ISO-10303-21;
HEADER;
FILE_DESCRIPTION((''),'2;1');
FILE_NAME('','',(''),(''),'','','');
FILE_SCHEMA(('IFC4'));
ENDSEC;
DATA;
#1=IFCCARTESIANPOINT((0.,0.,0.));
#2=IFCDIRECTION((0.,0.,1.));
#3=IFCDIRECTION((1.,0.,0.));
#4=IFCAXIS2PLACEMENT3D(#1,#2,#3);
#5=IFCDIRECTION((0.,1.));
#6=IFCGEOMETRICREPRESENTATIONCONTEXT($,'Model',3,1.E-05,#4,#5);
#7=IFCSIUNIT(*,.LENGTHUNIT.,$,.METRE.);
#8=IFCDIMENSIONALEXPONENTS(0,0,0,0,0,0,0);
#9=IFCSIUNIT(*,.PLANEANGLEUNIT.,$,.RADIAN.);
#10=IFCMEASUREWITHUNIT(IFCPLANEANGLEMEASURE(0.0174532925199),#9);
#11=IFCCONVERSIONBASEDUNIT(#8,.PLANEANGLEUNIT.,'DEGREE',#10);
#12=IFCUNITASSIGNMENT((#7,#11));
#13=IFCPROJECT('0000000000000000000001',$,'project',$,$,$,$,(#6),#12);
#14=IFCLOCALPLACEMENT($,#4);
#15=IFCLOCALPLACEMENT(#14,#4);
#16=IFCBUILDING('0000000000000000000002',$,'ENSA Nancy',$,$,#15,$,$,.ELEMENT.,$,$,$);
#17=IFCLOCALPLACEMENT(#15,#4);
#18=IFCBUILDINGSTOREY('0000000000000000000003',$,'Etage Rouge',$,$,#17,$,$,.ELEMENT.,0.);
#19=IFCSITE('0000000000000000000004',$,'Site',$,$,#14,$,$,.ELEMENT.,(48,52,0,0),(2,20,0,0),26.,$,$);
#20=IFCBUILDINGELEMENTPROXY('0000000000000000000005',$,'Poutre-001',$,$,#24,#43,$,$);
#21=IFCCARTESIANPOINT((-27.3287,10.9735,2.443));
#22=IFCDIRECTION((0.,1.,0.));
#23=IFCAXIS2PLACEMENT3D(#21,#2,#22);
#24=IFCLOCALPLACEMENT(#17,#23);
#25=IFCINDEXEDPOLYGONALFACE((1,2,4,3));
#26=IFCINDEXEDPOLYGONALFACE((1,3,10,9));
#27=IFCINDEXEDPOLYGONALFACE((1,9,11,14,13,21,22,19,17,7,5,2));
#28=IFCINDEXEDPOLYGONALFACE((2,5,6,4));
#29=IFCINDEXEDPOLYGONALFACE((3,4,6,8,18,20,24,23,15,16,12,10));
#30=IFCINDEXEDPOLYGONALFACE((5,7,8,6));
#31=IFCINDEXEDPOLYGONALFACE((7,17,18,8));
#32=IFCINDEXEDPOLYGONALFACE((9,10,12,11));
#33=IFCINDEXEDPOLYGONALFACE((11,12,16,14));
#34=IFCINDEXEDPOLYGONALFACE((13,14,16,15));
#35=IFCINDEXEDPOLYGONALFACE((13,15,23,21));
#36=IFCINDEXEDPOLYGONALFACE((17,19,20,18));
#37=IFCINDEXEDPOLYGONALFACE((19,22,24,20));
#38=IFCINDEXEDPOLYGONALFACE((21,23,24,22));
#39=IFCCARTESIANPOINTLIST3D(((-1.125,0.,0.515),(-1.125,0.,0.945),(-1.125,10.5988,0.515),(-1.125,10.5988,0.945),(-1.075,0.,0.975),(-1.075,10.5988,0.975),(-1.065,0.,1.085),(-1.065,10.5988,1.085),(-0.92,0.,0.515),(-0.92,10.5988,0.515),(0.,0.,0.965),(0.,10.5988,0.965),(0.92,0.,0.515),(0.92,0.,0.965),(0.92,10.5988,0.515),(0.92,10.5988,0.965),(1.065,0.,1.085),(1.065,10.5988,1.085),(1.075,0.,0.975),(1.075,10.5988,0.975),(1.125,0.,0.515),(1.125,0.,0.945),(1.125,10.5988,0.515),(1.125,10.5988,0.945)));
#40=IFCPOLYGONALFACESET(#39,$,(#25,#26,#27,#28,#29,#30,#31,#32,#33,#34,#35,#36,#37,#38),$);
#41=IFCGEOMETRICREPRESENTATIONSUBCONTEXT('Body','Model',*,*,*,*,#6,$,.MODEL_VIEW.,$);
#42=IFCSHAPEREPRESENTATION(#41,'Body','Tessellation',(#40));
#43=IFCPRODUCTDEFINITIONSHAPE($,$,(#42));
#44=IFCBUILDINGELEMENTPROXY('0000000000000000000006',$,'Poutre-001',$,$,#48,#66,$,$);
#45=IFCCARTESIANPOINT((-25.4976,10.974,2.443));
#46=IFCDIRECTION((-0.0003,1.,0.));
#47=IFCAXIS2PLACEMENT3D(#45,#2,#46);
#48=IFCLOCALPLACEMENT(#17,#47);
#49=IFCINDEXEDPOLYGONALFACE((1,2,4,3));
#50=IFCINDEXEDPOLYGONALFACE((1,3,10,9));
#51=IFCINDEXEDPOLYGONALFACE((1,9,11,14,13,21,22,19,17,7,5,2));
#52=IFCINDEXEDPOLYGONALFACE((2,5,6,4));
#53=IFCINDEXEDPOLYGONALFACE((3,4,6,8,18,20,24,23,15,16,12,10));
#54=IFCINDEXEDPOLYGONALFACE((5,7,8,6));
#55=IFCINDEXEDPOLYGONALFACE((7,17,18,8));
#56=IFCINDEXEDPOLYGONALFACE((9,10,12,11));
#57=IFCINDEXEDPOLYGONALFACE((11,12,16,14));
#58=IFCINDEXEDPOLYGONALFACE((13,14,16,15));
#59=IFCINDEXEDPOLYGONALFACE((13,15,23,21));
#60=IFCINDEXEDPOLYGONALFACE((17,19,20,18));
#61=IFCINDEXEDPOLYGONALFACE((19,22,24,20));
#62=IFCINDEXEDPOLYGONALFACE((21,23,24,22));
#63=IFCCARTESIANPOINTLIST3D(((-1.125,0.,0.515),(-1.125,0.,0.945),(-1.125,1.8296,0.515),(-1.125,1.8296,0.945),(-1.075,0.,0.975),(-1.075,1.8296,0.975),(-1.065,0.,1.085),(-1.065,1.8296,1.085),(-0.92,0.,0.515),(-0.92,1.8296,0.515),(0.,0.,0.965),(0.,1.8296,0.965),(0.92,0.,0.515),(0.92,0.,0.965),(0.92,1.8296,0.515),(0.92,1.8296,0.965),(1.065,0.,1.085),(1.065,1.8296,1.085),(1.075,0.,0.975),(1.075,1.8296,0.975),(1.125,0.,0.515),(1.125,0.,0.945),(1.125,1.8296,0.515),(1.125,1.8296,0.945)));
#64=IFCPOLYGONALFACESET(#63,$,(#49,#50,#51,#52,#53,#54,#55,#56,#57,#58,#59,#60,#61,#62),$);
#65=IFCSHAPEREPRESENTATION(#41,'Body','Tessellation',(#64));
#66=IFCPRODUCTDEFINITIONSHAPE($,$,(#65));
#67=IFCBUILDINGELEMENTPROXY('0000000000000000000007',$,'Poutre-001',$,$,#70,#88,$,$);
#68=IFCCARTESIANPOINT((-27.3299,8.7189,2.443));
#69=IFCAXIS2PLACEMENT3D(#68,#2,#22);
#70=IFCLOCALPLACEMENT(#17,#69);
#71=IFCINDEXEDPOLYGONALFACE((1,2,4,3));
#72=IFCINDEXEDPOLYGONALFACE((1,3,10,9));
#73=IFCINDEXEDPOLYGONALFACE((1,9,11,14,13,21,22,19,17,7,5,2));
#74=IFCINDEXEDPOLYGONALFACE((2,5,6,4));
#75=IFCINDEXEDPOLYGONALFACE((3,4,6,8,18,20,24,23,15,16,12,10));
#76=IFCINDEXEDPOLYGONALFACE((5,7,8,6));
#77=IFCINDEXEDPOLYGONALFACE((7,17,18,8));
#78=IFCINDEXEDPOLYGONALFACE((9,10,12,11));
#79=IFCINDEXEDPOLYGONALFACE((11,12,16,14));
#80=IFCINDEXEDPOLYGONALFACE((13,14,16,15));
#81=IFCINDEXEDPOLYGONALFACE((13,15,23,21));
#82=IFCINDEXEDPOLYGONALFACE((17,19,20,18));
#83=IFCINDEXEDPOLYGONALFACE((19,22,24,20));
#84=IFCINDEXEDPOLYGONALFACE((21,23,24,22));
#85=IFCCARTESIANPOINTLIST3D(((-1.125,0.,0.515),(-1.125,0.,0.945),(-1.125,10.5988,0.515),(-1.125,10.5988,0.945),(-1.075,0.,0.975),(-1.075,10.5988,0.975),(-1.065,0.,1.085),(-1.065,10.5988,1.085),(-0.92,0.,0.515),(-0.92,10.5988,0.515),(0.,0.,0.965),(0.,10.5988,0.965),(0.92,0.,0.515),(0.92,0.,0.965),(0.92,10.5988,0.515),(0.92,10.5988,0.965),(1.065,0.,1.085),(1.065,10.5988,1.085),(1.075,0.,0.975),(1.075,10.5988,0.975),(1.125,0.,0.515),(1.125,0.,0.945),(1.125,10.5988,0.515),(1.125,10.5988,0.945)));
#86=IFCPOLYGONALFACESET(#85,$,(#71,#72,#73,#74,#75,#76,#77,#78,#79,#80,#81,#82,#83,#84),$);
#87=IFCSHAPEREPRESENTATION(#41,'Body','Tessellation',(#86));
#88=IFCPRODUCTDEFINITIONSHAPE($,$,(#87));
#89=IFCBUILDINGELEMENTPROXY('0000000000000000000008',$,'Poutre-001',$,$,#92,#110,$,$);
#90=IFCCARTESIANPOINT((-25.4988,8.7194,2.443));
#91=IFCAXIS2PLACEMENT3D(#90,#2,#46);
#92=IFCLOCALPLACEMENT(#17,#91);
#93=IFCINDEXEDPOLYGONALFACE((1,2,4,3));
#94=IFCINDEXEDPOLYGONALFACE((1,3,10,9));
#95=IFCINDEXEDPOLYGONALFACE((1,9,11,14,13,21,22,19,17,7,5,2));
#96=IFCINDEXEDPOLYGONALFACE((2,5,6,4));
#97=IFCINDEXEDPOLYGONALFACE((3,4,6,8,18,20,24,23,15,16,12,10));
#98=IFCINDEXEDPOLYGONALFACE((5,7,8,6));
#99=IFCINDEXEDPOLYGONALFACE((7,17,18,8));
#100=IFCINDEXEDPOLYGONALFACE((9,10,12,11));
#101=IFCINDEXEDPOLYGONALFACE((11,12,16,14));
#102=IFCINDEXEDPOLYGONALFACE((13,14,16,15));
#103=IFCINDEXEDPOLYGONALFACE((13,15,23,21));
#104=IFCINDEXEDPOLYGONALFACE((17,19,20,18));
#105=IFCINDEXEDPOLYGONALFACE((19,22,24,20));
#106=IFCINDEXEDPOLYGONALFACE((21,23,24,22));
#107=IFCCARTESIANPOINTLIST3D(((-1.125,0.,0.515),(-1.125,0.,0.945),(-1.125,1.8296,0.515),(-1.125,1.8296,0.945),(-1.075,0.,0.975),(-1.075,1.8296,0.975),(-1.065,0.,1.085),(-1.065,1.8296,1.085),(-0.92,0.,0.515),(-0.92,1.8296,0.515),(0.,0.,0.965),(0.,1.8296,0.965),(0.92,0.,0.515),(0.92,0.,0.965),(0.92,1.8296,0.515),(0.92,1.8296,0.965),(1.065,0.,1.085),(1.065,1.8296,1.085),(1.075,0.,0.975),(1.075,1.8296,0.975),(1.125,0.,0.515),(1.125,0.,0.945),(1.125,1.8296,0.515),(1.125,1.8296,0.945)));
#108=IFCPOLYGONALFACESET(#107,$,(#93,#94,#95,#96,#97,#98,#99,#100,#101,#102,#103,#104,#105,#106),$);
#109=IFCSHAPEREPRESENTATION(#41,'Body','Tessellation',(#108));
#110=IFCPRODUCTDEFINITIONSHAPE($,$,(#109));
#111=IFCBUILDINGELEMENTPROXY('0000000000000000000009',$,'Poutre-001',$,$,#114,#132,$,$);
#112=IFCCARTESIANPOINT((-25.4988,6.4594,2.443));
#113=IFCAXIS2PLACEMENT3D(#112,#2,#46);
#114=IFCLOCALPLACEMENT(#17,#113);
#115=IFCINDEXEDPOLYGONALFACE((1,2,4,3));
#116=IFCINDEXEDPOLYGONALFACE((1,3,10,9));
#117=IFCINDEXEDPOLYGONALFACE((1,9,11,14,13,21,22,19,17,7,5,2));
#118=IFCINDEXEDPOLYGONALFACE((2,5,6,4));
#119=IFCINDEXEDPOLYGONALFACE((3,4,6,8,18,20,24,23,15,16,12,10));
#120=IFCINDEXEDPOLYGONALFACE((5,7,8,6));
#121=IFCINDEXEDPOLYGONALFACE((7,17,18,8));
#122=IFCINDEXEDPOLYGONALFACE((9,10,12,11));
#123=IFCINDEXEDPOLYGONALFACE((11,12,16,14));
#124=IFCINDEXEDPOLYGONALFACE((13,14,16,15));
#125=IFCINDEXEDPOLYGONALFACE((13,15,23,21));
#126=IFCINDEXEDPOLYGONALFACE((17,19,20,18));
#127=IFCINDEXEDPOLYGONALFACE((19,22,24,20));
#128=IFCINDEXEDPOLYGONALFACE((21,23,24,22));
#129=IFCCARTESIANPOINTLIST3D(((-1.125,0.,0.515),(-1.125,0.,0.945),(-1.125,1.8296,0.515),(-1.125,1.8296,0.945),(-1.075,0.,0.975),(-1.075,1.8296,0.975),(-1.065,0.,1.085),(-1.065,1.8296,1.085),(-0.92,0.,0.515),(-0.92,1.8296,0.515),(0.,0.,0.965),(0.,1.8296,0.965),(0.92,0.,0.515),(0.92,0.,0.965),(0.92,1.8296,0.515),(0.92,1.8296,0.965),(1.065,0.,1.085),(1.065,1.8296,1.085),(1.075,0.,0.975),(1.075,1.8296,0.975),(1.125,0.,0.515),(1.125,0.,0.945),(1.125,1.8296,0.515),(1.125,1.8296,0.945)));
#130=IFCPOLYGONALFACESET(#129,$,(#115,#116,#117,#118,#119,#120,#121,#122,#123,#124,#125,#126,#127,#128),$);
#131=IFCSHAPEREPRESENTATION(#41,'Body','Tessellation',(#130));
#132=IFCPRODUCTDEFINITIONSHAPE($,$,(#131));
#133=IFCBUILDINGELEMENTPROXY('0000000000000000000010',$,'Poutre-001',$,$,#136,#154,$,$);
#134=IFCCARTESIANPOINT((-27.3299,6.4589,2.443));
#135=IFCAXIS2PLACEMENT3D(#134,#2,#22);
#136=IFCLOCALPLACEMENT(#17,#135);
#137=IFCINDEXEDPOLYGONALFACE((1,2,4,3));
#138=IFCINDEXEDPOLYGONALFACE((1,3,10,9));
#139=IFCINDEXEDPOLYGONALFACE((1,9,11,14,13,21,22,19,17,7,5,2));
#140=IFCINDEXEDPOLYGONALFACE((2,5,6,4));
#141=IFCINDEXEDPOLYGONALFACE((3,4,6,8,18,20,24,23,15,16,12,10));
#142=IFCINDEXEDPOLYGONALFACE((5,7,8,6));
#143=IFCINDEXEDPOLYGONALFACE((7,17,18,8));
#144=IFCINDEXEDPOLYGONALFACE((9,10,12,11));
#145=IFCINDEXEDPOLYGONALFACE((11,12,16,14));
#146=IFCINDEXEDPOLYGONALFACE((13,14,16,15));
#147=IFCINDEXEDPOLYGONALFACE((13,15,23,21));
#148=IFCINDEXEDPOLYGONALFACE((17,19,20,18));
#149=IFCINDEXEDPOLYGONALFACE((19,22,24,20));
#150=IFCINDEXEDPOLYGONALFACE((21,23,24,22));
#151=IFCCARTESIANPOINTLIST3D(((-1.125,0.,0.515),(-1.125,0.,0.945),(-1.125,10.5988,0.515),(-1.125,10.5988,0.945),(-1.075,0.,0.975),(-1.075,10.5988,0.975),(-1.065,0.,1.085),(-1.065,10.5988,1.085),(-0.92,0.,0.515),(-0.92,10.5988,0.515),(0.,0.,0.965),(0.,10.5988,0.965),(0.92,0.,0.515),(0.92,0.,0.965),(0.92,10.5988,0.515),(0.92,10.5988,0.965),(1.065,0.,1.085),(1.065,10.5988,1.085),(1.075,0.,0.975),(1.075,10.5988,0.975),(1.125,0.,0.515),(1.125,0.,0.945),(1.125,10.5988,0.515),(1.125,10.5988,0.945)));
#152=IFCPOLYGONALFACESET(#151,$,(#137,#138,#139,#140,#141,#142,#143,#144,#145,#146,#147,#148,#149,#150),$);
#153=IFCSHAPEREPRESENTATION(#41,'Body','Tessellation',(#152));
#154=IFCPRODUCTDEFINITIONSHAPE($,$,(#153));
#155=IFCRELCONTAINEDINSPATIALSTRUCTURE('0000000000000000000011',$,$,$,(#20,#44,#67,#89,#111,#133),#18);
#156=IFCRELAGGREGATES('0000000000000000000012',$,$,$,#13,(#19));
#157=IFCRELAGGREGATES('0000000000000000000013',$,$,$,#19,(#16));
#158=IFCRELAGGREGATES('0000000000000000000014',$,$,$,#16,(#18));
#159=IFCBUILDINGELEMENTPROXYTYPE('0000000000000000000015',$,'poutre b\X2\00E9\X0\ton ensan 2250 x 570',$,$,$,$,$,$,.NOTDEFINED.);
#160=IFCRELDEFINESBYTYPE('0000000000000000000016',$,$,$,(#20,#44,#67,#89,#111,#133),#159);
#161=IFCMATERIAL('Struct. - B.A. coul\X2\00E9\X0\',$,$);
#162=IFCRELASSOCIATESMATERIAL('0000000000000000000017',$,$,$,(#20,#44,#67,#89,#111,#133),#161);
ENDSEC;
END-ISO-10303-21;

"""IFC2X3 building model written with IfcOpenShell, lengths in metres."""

from ifc_helpers import new_model, entity, si_unit, converted_unit, direction, frame, origin_with_axes, place, context, subcontext, project, spatial, polyline, outline, extrude, material, type_object, element, save


model = new_model("IFC2X3")

# Units and contexts
model_context = context("Model", 3, precision=1e-05, world=origin_with_axes(), true_north=direction((0.0, 1.0)))
body_context = subcontext(model_context, "Body", "Model", "MODEL_VIEW")
ifc_project = project(units=[si_unit("LENGTHUNIT", "METRE"), converted_unit("PLANEANGLEUNIT", "DEGREE", entity("IfcPlaneAngleMeasure", 0.0174532925199), si_unit("PLANEANGLEUNIT", "RADIAN"), dimensions=[0, 0, 0, 0, 0, 0, 0])], contexts=[model_context])

# Site, building, storey
site_placement = place(None, origin_with_axes())
site = spatial("IfcSite", under=ifc_project, at=site_placement, Name="Site", CompositionType="ELEMENT", RefLatitude=(48, 52, 0, 0), RefLongitude=(2, 20, 0, 0), RefElevation=26.0)
building_placement = place(site_placement, origin_with_axes())
building = spatial("IfcBuilding", under=site, at=building_placement, Name="ENSA Nancy", CompositionType="ELEMENT")
storey_placement = place(building_placement, origin_with_axes())
storey = spatial("IfcBuildingStorey", under=building, at=storey_placement, Name="Etage Rouge", CompositionType="ELEMENT", Elevation=0.0)

# Building element proxies
ifc_material_1 = material(Name="Struct. - B.A. coulé")
building_element_proxy_type_1 = type_object("IfcBuildingElementProxyType", Name="poutre béton ensan 2250 x 570", PredefinedType="NOTDEFINED")
proxy_1_placement = place(storey_placement, frame((-27.3287, 10.9735, 2.443), z_axis=(0.0, 0.0, 1.0), x_axis=(0.0, 1.0, 0.0)))
element("IfcBuildingElementProxy", 1, at=proxy_1_placement, inside=storey, type_object=building_element_proxy_type_1, material=ifc_material_1, Name="Poutre-001", context=body_context, shape_type="SweptSolid", body=[
    extrude(outline(polyline([(-1.065, 1.085), (-1.075, 0.975), (-1.125, 0.945), (-1.125, 0.515), (-0.92, 0.515), (0.0, 0.965), (0.92, 0.965), (0.92, 0.515), (1.125, 0.515), (1.125, 0.945), (1.075, 0.975), (1.065, 1.085), (-1.065, 1.085)])), frame((0.0, 10.5988, 0.0), z_axis=(0.0, -1.0, 0.0), x_axis=(1.0, 0.0, 0.0)), (0.0, 0.0, 1.0), 10.5988),
])
proxy_2_placement = place(storey_placement, frame((-25.4976, 10.974, 2.443), z_axis=(0.0, 0.0, 1.0), x_axis=(-0.0003, 1.0, 0.0)))
element("IfcBuildingElementProxy", 2, at=proxy_2_placement, inside=storey, type_object=building_element_proxy_type_1, material=ifc_material_1, Name="Poutre-001", context=body_context, shape_type="SweptSolid", body=[
    extrude(outline(polyline([(-1.065, 1.085), (-1.075, 0.975), (-1.125, 0.945), (-1.125, 0.515), (-0.92, 0.515), (0.0, 0.965), (0.92, 0.965), (0.92, 0.515), (1.125, 0.515), (1.125, 0.945), (1.075, 0.975), (1.065, 1.085), (-1.065, 1.085)])), frame((0.0, 1.8296, 0.0), z_axis=(0.0, -1.0, 0.0), x_axis=(1.0, 0.0, 0.0)), (0.0, 0.0, 1.0), 1.8296),
])
proxy_3_placement = place(storey_placement, frame((-27.3299, 8.7189, 2.443), z_axis=(0.0, 0.0, 1.0), x_axis=(0.0, 1.0, 0.0)))
element("IfcBuildingElementProxy", 3, at=proxy_3_placement, inside=storey, type_object=building_element_proxy_type_1, material=ifc_material_1, Name="Poutre-001", context=body_context, shape_type="SweptSolid", body=[
    extrude(outline(polyline([(-1.065, 1.085), (-1.075, 0.975), (-1.125, 0.945), (-1.125, 0.515), (-0.92, 0.515), (0.0, 0.965), (0.92, 0.965), (0.92, 0.515), (1.125, 0.515), (1.125, 0.945), (1.075, 0.975), (1.065, 1.085), (-1.065, 1.085)])), frame((0.0, 10.5988, 0.0), z_axis=(0.0, -1.0, 0.0), x_axis=(1.0, 0.0, 0.0)), (0.0, 0.0, 1.0), 10.5988),
])
for number, where, z_axis, x_axis, name in (
    (4, (-25.4988, 8.7194, 2.443), (0.0, 0.0, 1.0), (-0.0003, 1.0, 0.0), "Poutre-001"),
    (5, (-25.4988, 6.4594, 2.443), (0.0, 0.0, 1.0), (-0.0003, 1.0, 0.0), "Poutre-001"),
):
    element("IfcBuildingElementProxy", number, at=place(storey_placement, frame(where, z_axis=z_axis, x_axis=x_axis)), inside=storey, type_object=building_element_proxy_type_1, material=ifc_material_1, Name=name, context=body_context, shape_type="SweptSolid", body=[
        extrude(outline(polyline([(-1.065, 1.085), (-1.075, 0.975), (-1.125, 0.945), (-1.125, 0.515), (-0.92, 0.515), (0.0, 0.965), (0.92, 0.965), (0.92, 0.515), (1.125, 0.515), (1.125, 0.945), (1.075, 0.975), (1.065, 1.085), (-1.065, 1.085)])), frame((0.0, 1.8296, 0.0), z_axis=(0.0, -1.0, 0.0), x_axis=(1.0, 0.0, 0.0)), (0.0, 0.0, 1.0), 1.8296),
    ])
proxy_4_placement = place(storey_placement, frame((-27.3299, 6.4589, 2.443), z_axis=(0.0, 0.0, 1.0), x_axis=(0.0, 1.0, 0.0)))
element("IfcBuildingElementProxy", 6, at=proxy_4_placement, inside=storey, type_object=building_element_proxy_type_1, material=ifc_material_1, Name="Poutre-001", context=body_context, shape_type="SweptSolid", body=[
    extrude(outline(polyline([(-1.065, 1.085), (-1.075, 0.975), (-1.125, 0.945), (-1.125, 0.515), (-0.92, 0.515), (0.0, 0.965), (0.92, 0.965), (0.92, 0.515), (1.125, 0.515), (1.125, 0.945), (1.075, 0.975), (1.065, 1.085), (-1.065, 1.085)])), frame((0.0, 10.5988, 0.0), z_axis=(0.0, -1.0, 0.0), x_axis=(1.0, 0.0, 0.0)), (0.0, 0.0, 1.0), 10.5988),
])

save(model, "model.ifc")
